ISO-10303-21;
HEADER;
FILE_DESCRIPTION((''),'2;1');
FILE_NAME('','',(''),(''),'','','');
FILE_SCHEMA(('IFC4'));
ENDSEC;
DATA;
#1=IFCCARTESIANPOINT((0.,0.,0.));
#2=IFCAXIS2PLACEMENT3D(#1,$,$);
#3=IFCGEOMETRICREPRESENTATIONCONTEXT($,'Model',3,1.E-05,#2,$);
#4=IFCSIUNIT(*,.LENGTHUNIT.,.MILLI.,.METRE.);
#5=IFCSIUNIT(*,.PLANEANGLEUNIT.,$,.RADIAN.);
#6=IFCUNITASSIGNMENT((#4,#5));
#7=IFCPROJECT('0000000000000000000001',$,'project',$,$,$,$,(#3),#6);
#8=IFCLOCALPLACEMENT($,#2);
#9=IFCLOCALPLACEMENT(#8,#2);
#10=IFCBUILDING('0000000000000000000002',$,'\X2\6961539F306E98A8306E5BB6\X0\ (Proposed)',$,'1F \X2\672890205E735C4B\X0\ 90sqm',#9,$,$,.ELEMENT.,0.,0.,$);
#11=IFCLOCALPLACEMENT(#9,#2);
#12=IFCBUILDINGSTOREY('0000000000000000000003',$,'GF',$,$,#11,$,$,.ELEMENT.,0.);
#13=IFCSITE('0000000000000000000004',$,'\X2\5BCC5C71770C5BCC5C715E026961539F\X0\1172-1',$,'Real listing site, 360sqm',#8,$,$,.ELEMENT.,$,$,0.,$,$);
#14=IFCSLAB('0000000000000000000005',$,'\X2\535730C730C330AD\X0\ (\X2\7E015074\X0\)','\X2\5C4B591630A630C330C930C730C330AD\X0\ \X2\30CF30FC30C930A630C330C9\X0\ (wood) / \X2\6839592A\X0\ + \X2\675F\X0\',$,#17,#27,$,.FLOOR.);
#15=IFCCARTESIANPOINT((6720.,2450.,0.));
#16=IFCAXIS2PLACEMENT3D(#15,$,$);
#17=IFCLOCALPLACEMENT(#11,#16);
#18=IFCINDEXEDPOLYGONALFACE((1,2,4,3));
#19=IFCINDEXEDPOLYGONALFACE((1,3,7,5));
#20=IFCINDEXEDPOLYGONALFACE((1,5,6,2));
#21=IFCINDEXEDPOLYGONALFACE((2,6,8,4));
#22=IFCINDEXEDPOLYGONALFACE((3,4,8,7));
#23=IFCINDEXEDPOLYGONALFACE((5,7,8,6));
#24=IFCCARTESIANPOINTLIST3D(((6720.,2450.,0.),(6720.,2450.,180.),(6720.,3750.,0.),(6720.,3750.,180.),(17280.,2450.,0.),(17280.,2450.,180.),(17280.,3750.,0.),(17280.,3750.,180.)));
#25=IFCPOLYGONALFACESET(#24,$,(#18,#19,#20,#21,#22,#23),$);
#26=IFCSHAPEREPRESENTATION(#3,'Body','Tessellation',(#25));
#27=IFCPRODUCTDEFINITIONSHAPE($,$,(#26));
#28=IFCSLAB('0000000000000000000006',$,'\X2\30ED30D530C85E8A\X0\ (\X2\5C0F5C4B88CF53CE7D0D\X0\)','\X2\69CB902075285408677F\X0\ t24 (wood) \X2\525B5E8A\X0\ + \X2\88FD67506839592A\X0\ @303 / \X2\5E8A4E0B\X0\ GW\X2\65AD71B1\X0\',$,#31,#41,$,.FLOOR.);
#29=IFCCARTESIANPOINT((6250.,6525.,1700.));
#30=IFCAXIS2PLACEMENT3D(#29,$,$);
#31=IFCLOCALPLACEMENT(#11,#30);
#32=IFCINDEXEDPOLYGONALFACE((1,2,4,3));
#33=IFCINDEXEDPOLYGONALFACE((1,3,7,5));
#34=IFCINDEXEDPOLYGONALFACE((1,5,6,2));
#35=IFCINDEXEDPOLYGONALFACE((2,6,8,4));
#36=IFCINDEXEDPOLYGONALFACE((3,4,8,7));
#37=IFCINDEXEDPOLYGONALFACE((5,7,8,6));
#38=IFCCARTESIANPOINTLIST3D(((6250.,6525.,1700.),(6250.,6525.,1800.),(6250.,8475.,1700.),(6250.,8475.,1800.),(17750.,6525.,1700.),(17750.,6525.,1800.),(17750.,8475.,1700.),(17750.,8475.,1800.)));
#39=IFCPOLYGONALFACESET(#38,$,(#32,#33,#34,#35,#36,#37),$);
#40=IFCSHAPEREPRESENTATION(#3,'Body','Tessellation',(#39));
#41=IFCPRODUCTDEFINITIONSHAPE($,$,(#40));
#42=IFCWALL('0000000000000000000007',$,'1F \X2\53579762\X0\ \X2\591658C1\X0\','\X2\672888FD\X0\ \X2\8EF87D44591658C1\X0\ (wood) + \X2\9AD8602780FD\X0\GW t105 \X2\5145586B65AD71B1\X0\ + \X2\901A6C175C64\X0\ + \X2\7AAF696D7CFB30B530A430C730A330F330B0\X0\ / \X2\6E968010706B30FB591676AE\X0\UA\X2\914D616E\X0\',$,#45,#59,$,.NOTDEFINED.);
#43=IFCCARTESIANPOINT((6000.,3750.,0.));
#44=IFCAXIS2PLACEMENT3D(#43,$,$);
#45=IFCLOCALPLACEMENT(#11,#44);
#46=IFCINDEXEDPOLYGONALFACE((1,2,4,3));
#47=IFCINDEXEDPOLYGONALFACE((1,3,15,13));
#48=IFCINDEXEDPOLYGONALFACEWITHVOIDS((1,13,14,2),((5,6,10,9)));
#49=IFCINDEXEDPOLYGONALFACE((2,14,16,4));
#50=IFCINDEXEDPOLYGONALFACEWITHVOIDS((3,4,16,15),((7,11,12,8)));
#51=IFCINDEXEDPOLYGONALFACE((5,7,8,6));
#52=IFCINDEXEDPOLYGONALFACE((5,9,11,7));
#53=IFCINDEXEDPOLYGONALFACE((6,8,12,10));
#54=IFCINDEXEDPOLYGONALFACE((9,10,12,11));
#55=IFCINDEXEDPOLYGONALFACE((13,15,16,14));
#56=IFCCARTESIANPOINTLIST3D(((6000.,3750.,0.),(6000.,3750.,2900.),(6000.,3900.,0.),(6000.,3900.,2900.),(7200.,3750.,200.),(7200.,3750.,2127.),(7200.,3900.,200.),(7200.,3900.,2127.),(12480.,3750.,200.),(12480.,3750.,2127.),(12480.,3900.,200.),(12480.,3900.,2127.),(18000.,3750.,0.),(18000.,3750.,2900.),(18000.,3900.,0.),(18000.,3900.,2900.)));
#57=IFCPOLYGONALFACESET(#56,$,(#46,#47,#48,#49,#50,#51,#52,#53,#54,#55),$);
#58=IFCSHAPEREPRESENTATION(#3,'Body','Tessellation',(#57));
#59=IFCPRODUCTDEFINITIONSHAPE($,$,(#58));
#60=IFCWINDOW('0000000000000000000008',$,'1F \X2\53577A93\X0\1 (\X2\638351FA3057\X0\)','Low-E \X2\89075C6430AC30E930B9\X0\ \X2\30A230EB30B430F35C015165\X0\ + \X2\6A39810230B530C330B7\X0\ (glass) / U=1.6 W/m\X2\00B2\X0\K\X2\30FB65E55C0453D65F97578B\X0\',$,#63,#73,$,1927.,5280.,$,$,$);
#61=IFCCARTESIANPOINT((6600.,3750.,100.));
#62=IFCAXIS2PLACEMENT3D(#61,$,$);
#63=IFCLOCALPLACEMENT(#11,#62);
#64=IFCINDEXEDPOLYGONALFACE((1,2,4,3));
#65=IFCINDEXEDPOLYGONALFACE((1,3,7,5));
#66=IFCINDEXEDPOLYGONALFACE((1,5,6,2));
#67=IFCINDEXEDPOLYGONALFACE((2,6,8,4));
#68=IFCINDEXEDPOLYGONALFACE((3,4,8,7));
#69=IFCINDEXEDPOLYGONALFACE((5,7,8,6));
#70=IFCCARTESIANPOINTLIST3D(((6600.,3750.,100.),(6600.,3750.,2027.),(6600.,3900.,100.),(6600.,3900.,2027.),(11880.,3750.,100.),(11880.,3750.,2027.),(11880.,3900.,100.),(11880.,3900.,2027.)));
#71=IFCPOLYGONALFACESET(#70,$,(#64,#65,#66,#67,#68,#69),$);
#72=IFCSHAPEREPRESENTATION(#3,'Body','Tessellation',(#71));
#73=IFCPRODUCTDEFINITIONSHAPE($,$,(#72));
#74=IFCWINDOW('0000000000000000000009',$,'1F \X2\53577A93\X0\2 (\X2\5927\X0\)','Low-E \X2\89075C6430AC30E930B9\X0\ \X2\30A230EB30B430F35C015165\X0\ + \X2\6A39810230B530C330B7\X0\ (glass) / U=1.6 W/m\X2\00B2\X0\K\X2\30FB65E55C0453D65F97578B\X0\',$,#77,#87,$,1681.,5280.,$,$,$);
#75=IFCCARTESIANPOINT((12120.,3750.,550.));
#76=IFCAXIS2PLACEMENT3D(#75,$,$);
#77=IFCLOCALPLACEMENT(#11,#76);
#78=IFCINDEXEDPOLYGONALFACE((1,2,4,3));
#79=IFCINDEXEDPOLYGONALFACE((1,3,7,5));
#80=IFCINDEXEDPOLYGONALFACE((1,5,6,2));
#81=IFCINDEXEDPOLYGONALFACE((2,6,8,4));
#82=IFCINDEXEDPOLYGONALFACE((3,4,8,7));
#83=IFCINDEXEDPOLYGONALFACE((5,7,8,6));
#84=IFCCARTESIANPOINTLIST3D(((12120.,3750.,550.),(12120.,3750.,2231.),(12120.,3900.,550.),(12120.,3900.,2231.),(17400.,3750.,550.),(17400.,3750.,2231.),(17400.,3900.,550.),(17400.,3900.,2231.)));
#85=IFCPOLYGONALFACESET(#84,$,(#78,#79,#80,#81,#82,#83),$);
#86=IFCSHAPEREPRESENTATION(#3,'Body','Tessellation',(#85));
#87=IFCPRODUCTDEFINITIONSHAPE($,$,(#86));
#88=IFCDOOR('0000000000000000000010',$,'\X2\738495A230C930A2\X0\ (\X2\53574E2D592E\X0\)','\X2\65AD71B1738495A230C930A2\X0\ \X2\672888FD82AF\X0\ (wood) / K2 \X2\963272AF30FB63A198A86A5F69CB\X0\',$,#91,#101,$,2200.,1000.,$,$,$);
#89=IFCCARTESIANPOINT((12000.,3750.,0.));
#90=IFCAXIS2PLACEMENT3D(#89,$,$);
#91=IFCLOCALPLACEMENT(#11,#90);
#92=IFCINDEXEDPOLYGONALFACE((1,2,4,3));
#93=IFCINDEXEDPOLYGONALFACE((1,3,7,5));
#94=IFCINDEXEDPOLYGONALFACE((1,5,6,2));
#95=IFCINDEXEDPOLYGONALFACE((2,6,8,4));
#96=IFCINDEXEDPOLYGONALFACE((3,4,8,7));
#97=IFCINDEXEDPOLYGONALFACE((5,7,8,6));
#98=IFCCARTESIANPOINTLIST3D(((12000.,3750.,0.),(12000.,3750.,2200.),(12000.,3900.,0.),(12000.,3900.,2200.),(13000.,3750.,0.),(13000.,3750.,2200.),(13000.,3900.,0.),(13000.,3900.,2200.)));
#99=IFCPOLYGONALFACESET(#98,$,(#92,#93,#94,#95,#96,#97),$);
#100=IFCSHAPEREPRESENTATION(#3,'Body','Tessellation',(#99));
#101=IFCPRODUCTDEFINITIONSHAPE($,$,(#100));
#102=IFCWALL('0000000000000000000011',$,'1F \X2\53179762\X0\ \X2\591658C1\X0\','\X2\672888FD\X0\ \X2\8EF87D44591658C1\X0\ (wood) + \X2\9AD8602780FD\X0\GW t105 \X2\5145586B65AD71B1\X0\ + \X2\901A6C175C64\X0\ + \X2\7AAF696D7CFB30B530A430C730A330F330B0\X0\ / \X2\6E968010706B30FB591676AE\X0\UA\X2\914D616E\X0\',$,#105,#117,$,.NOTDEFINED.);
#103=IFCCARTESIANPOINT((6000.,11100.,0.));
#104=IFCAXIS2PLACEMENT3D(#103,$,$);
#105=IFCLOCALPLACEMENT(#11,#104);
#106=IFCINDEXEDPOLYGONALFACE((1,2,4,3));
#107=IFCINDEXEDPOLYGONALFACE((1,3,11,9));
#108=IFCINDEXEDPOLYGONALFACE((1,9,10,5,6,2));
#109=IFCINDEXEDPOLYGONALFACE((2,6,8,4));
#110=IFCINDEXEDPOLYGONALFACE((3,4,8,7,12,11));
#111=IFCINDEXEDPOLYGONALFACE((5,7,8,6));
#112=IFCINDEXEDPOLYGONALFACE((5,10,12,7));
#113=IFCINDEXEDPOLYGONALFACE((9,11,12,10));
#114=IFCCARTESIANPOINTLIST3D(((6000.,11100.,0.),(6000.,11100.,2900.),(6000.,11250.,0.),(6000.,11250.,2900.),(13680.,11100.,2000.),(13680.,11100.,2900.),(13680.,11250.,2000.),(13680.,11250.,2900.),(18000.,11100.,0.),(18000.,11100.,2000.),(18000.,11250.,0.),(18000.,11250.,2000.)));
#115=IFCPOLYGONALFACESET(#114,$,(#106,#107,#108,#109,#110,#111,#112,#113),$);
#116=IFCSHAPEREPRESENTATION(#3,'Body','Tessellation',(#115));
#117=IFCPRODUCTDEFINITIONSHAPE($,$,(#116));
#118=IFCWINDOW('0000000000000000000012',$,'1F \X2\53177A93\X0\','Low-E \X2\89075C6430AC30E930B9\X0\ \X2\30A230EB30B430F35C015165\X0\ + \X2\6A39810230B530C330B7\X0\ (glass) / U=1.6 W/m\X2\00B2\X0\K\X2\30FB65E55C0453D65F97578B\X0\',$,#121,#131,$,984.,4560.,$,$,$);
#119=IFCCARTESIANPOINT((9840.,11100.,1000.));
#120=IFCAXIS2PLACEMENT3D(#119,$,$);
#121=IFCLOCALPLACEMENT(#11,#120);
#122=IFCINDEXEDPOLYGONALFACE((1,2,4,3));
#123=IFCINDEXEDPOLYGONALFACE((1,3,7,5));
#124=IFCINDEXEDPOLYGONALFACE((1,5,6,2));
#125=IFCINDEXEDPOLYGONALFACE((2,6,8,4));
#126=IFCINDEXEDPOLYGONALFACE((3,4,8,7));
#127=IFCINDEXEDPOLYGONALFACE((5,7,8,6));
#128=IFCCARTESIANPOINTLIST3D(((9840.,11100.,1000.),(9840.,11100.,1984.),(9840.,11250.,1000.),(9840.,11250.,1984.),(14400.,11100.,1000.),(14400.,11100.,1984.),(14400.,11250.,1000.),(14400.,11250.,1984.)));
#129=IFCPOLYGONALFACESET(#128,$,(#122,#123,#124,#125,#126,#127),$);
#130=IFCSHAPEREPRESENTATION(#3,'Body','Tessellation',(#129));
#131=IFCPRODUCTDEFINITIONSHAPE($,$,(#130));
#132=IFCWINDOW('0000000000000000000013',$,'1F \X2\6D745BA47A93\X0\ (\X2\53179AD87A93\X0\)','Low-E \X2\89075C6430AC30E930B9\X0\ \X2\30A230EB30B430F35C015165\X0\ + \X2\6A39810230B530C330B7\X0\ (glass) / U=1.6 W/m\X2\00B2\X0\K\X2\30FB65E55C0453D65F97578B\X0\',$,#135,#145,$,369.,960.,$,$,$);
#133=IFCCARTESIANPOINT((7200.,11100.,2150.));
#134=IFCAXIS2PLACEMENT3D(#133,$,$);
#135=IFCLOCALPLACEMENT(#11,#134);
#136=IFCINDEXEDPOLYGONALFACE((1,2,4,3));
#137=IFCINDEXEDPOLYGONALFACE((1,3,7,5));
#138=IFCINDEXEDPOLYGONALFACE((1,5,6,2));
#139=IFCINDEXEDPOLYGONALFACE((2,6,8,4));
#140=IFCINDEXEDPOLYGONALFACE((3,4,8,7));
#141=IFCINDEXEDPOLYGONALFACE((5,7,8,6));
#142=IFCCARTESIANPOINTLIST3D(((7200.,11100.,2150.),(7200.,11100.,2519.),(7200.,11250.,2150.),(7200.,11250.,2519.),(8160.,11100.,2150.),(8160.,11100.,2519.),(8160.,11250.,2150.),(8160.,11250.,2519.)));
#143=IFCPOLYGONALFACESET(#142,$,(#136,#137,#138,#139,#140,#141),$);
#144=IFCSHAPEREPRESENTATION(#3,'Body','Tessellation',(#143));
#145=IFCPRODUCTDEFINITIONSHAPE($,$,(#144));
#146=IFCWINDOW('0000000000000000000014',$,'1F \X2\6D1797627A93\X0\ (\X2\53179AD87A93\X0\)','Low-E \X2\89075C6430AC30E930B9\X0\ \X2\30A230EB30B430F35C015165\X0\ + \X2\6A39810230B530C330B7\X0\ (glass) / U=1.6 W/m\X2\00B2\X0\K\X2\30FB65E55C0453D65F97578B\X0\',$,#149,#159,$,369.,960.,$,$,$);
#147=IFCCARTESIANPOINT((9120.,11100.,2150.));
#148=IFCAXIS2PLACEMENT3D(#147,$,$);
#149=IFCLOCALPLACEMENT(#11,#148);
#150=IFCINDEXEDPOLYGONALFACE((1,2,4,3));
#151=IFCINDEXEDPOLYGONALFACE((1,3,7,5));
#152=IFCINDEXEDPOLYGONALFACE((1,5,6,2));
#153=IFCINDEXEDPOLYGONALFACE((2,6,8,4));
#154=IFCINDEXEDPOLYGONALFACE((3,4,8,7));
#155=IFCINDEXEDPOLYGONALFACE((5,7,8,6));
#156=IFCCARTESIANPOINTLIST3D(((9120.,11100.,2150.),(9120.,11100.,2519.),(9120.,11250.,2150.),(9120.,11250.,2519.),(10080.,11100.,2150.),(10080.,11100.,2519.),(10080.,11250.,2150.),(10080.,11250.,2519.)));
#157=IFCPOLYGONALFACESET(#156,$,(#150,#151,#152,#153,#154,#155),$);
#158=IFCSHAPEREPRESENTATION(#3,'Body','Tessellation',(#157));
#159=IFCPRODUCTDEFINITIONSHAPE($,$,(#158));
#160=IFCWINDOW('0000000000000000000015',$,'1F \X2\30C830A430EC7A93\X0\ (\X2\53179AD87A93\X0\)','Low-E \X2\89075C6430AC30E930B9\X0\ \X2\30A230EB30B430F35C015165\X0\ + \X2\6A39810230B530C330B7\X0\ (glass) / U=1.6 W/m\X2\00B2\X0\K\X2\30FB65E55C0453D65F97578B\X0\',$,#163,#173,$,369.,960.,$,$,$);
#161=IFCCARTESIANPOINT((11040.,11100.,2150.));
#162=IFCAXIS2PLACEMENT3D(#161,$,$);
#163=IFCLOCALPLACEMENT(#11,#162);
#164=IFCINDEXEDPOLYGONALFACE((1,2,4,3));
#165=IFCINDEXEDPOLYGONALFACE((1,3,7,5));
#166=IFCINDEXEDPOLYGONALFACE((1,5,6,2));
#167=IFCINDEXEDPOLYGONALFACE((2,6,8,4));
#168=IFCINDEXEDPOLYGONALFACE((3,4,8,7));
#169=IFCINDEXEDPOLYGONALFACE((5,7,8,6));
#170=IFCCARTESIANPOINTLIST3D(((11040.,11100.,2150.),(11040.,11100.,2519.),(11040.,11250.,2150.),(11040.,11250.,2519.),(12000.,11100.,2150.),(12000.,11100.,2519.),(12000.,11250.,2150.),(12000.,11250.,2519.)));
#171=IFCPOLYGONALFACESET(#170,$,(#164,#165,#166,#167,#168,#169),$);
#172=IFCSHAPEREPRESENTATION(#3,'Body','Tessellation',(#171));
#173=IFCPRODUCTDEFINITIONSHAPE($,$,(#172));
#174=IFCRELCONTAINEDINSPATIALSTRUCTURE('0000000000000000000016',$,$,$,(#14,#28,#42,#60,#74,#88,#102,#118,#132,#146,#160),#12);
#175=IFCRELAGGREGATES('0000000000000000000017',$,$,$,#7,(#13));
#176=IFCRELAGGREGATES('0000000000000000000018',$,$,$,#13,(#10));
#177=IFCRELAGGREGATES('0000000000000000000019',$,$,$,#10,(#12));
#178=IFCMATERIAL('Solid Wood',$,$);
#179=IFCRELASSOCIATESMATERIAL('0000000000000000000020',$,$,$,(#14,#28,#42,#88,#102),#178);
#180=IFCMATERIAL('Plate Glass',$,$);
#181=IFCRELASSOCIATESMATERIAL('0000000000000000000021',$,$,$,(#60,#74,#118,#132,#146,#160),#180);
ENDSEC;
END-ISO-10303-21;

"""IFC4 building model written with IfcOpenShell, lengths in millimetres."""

from ifc_helpers import new_model, si_unit, frame, frame_2d, origin, place, context, project, spatial, rectangle, extrude, material, element, fill, save


model = new_model("IFC4")

# Units and contexts
model_context = context("Model", 3, precision=1e-05, world=origin())
ifc_project = project(units=[si_unit("LENGTHUNIT", "METRE", prefix="MILLI"), si_unit("PLANEANGLEUNIT", "RADIAN")], contexts=[model_context])

# Site, building, storey
site_placement = place(None, origin())
site = spatial("IfcSite", under=ifc_project, at=site_placement, Name="富山県富山市楡原1172-1", ObjectType="Real listing site, 360sqm", CompositionType="ELEMENT", RefElevation=0.0)
building_placement = place(site_placement, origin())
building = spatial("IfcBuilding", under=site, at=building_placement, Name="楡原の風の家 (Proposed)", ObjectType="1F 木造平屋 90sqm", CompositionType="ELEMENT", ElevationOfRefHeight=0.0, ElevationOfTerrain=0.0)
storey_placement = place(building_placement, origin())
storey = spatial("IfcBuildingStorey", under=building, at=storey_placement, Name="GF", CompositionType="ELEMENT", Elevation=0.0)

# Slabs
ifc_material_1 = material(Name="Solid Wood")
slab_1_placement = place(storey_placement, frame((6720.0, 2450.0, 0.0)))
element("IfcSlab", 1, at=slab_1_placement, inside=storey, material=ifc_material_1, Name="南デッキ (縁側)", Description="屋外ウッドデッキ ハードウッド (wood) / 根太 + 束", PredefinedType="FLOOR", context=model_context, shape_type="SweptSolid", body=[
    extrude(rectangle(XDim=10560.0, YDim=1300.0, at=frame_2d((5280.0, 650.0))), frame((6720.0, 2450.0, 0.0)), (0.0, 0.0, 1.0), 180.0),
])
slab_2_placement = place(storey_placement, frame((6250.0, 6525.0, 1700.0)))
element("IfcSlab", 2, at=slab_2_placement, inside=storey, material=ifc_material_1, Name="ロフト床 (小屋裏収納)", Description="構造用合板 t24 (wood) 剛床 + 製材根太 @303 / 床下 GW断熱", PredefinedType="FLOOR", context=model_context, shape_type="SweptSolid", body=[
    extrude(rectangle(XDim=11500.0, YDim=1950.0, at=frame_2d((5750.0, 975.0))), frame((6250.0, 6525.0, 1700.0)), (0.0, 0.0, 1.0), 100.0),
])

# Wall, openings, windows, door
wall_1_placement = place(storey_placement, frame((6000.0, 3750.0, 0.0)))
wall_1 = element("IfcWall", 3, at=wall_1_placement, inside=storey, material=ifc_material_1, Name="1F 南面 外壁", Description="木製 軸組外壁 (wood) + 高性能GW t105 充填断熱 + 通気層 + 窯業系サイディング / 準耐火・外皮UA配慮", PredefinedType="NOTDEFINED", context=model_context, shape_type="SweptSolid", body=[
    extrude(rectangle(XDim=12000.0, YDim=150.0, at=frame_2d((6000.0, 75.0))), frame((6000.0, 3750.0, 0.0)), (0.0, 0.0, 1.0), 2900.0),
])
opening_1_placement = place(storey_placement, frame((6600.0, 3750.0, 100.0)))
opening_1 = element("IfcOpeningElement", 4, at=opening_1_placement, cuts=wall_1, PredefinedType="NOTDEFINED", context=model_context, shape_type="SweptSolid", body=[
    extrude(rectangle(XDim=5280.0, YDim=150.0, at=frame_2d((2640.0, 75.0))), frame((6600.0, 3750.0, 100.0)), (0.0, 0.0, 1.0), 1927.0),
])
opening_2_placement = place(storey_placement, frame((12120.0, 3750.0, 550.0)))
opening_2 = element("IfcOpeningElement", 5, at=opening_2_placement, cuts=wall_1, PredefinedType="NOTDEFINED", context=model_context, shape_type="SweptSolid", body=[
    extrude(rectangle(XDim=5280.0, YDim=150.0, at=frame_2d((2640.0, 75.0))), frame((12120.0, 3750.0, 550.0)), (0.0, 0.0, 1.0), 1681.0),
])
opening_3_placement = place(storey_placement, frame((12000.0, 3750.0, 0.0)))
opening_3 = element("IfcOpeningElement", 6, at=opening_3_placement, cuts=wall_1, PredefinedType="NOTDEFINED", context=model_context, shape_type="SweptSolid", body=[
    extrude(rectangle(XDim=1000.0, YDim=150.0, at=frame_2d((500.0, 75.0))), frame((12000.0, 3750.0, 0.0)), (0.0, 0.0, 1.0), 2200.0),
])
ifc_material_2 = material(Name="Plate Glass")
window_1_placement = place(storey_placement, frame((6600.0, 3750.0, 100.0)))
window_1 = element("IfcWindow", 7, at=window_1_placement, inside=storey, material=ifc_material_2, Name="1F 南窓1 (掃出し)", Description="Low-E 複層ガラス アルゴン封入 + 樹脂サッシ (glass) / U=1.6 W/m²K・日射取得型", OverallHeight=1927.0, OverallWidth=5280.0, context=model_context, shape_type="SweptSolid", body=[
    extrude(rectangle(XDim=5280.0, YDim=150.0, at=frame_2d((2640.0, 75.0))), frame((6600.0, 3750.0, 100.0)), (0.0, 0.0, 1.0), 1927.0),
])
fill(opening_1, window_1)
window_2_placement = place(storey_placement, frame((12120.0, 3750.0, 550.0)))
window_2 = element("IfcWindow", 8, at=window_2_placement, inside=storey, material=ifc_material_2, Name="1F 南窓2 (大)", Description="Low-E 複層ガラス アルゴン封入 + 樹脂サッシ (glass) / U=1.6 W/m²K・日射取得型", OverallHeight=1681.0, OverallWidth=5280.0, context=model_context, shape_type="SweptSolid", body=[
    extrude(rectangle(XDim=5280.0, YDim=150.0, at=frame_2d((2640.0, 75.0))), frame((12120.0, 3750.0, 550.0)), (0.0, 0.0, 1.0), 1681.0),
])
fill(opening_2, window_2)
door_1_placement = place(storey_placement, frame((12000.0, 3750.0, 0.0)))
door_1 = element("IfcDoor", 9, at=door_1_placement, inside=storey, material=ifc_material_1, Name="玄関ドア (南中央)", Description="断熱玄関ドア 木製芯 (wood) / K2 防犯・採風機構", OverallHeight=2200.0, OverallWidth=1000.0, context=model_context, shape_type="SweptSolid", body=[
    extrude(rectangle(XDim=1000.0, YDim=150.0, at=frame_2d((500.0, 75.0))), frame((12000.0, 3750.0, 0.0)), (0.0, 0.0, 1.0), 2200.0),
])
fill(opening_3, door_1)

# Wall, openings, windows
wall_2_placement = place(storey_placement, frame((6000.0, 11100.0, 0.0)))
wall_2 = element("IfcWall", 10, at=wall_2_placement, inside=storey, material=ifc_material_1, Name="1F 北面 外壁", Description="木製 軸組外壁 (wood) + 高性能GW t105 充填断熱 + 通気層 + 窯業系サイディング / 準耐火・外皮UA配慮", PredefinedType="NOTDEFINED", context=model_context, shape_type="SweptSolid", body=[
    extrude(rectangle(XDim=12000.0, YDim=150.0, at=frame_2d((6000.0, 75.0))), frame((6000.0, 11100.0, 0.0)), (0.0, 0.0, 1.0), 2900.0),
])
opening_4_placement = place(storey_placement, frame((9840.0, 11100.0, 1000.0)))
opening_4 = element("IfcOpeningElement", 11, at=opening_4_placement, cuts=wall_2, PredefinedType="NOTDEFINED", context=model_context, shape_type="SweptSolid", body=[
    extrude(rectangle(XDim=4560.0, YDim=150.0, at=frame_2d((2280.0, 75.0))), frame((9840.0, 11100.0, 1000.0)), (0.0, 0.0, 1.0), 984.0),
])
opening_5_placement = place(storey_placement, frame((7200.0, 11100.0, 2150.0)))
opening_5 = element("IfcOpeningElement", 12, at=opening_5_placement, cuts=wall_2, PredefinedType="NOTDEFINED", context=model_context, shape_type="SweptSolid", body=[
    extrude(rectangle(XDim=960.0, YDim=150.0, at=frame_2d((480.0, 75.0))), frame((7200.0, 11100.0, 2150.0)), (0.0, 0.0, 1.0), 369.0),
])
opening_6_placement = place(storey_placement, frame((9120.0, 11100.0, 2150.0)))
opening_6 = element("IfcOpeningElement", 13, at=opening_6_placement, cuts=wall_2, PredefinedType="NOTDEFINED", context=model_context, shape_type="SweptSolid", body=[
    extrude(rectangle(XDim=960.0, YDim=150.0, at=frame_2d((480.0, 75.0))), frame((9120.0, 11100.0, 2150.0)), (0.0, 0.0, 1.0), 369.0),
])
opening_7_placement = place(storey_placement, frame((11040.0, 11100.0, 2150.0)))
opening_7 = element("IfcOpeningElement", 14, at=opening_7_placement, cuts=wall_2, PredefinedType="NOTDEFINED", context=model_context, shape_type="SweptSolid", body=[
    extrude(rectangle(XDim=960.0, YDim=150.0, at=frame_2d((480.0, 75.0))), frame((11040.0, 11100.0, 2150.0)), (0.0, 0.0, 1.0), 369.0),
])
window_3_placement = place(storey_placement, frame((9840.0, 11100.0, 1000.0)))
window_3 = element("IfcWindow", 15, at=window_3_placement, inside=storey, material=ifc_material_2, Name="1F 北窓", Description="Low-E 複層ガラス アルゴン封入 + 樹脂サッシ (glass) / U=1.6 W/m²K・日射取得型", OverallHeight=984.0, OverallWidth=4560.0, context=model_context, shape_type="SweptSolid", body=[
    extrude(rectangle(XDim=4560.0, YDim=150.0, at=frame_2d((2280.0, 75.0))), frame((9840.0, 11100.0, 1000.0)), (0.0, 0.0, 1.0), 984.0),
])
fill(opening_4, window_3)
window_4_placement = place(storey_placement, frame((7200.0, 11100.0, 2150.0)))
window_4 = element("IfcWindow", 16, at=window_4_placement, inside=storey, material=ifc_material_2, Name="1F 浴室窓 (北高窓)", Description="Low-E 複層ガラス アルゴン封入 + 樹脂サッシ (glass) / U=1.6 W/m²K・日射取得型", OverallHeight=369.0, OverallWidth=960.0, context=model_context, shape_type="SweptSolid", body=[
    extrude(rectangle(XDim=960.0, YDim=150.0, at=frame_2d((480.0, 75.0))), frame((7200.0, 11100.0, 2150.0)), (0.0, 0.0, 1.0), 369.0),
])
fill(opening_5, window_4)
window_5_placement = place(storey_placement, frame((9120.0, 11100.0, 2150.0)))
window_5 = element("IfcWindow", 17, at=window_5_placement, inside=storey, material=ifc_material_2, Name="1F 洗面窓 (北高窓)", Description="Low-E 複層ガラス アルゴン封入 + 樹脂サッシ (glass) / U=1.6 W/m²K・日射取得型", OverallHeight=369.0, OverallWidth=960.0, context=model_context, shape_type="SweptSolid", body=[
    extrude(rectangle(XDim=960.0, YDim=150.0, at=frame_2d((480.0, 75.0))), frame((9120.0, 11100.0, 2150.0)), (0.0, 0.0, 1.0), 369.0),
])
fill(opening_6, window_5)
window_6_placement = place(storey_placement, frame((11040.0, 11100.0, 2150.0)))
window_6 = element("IfcWindow", 18, at=window_6_placement, inside=storey, material=ifc_material_2, Name="1F トイレ窓 (北高窓)", Description="Low-E 複層ガラス アルゴン封入 + 樹脂サッシ (glass) / U=1.6 W/m²K・日射取得型", OverallHeight=369.0, OverallWidth=960.0, context=model_context, shape_type="SweptSolid", body=[
    extrude(rectangle(XDim=960.0, YDim=150.0, at=frame_2d((480.0, 75.0))), frame((11040.0, 11100.0, 2150.0)), (0.0, 0.0, 1.0), 369.0),
])
fill(opening_7, window_6)

save(model, "model.ifc")
